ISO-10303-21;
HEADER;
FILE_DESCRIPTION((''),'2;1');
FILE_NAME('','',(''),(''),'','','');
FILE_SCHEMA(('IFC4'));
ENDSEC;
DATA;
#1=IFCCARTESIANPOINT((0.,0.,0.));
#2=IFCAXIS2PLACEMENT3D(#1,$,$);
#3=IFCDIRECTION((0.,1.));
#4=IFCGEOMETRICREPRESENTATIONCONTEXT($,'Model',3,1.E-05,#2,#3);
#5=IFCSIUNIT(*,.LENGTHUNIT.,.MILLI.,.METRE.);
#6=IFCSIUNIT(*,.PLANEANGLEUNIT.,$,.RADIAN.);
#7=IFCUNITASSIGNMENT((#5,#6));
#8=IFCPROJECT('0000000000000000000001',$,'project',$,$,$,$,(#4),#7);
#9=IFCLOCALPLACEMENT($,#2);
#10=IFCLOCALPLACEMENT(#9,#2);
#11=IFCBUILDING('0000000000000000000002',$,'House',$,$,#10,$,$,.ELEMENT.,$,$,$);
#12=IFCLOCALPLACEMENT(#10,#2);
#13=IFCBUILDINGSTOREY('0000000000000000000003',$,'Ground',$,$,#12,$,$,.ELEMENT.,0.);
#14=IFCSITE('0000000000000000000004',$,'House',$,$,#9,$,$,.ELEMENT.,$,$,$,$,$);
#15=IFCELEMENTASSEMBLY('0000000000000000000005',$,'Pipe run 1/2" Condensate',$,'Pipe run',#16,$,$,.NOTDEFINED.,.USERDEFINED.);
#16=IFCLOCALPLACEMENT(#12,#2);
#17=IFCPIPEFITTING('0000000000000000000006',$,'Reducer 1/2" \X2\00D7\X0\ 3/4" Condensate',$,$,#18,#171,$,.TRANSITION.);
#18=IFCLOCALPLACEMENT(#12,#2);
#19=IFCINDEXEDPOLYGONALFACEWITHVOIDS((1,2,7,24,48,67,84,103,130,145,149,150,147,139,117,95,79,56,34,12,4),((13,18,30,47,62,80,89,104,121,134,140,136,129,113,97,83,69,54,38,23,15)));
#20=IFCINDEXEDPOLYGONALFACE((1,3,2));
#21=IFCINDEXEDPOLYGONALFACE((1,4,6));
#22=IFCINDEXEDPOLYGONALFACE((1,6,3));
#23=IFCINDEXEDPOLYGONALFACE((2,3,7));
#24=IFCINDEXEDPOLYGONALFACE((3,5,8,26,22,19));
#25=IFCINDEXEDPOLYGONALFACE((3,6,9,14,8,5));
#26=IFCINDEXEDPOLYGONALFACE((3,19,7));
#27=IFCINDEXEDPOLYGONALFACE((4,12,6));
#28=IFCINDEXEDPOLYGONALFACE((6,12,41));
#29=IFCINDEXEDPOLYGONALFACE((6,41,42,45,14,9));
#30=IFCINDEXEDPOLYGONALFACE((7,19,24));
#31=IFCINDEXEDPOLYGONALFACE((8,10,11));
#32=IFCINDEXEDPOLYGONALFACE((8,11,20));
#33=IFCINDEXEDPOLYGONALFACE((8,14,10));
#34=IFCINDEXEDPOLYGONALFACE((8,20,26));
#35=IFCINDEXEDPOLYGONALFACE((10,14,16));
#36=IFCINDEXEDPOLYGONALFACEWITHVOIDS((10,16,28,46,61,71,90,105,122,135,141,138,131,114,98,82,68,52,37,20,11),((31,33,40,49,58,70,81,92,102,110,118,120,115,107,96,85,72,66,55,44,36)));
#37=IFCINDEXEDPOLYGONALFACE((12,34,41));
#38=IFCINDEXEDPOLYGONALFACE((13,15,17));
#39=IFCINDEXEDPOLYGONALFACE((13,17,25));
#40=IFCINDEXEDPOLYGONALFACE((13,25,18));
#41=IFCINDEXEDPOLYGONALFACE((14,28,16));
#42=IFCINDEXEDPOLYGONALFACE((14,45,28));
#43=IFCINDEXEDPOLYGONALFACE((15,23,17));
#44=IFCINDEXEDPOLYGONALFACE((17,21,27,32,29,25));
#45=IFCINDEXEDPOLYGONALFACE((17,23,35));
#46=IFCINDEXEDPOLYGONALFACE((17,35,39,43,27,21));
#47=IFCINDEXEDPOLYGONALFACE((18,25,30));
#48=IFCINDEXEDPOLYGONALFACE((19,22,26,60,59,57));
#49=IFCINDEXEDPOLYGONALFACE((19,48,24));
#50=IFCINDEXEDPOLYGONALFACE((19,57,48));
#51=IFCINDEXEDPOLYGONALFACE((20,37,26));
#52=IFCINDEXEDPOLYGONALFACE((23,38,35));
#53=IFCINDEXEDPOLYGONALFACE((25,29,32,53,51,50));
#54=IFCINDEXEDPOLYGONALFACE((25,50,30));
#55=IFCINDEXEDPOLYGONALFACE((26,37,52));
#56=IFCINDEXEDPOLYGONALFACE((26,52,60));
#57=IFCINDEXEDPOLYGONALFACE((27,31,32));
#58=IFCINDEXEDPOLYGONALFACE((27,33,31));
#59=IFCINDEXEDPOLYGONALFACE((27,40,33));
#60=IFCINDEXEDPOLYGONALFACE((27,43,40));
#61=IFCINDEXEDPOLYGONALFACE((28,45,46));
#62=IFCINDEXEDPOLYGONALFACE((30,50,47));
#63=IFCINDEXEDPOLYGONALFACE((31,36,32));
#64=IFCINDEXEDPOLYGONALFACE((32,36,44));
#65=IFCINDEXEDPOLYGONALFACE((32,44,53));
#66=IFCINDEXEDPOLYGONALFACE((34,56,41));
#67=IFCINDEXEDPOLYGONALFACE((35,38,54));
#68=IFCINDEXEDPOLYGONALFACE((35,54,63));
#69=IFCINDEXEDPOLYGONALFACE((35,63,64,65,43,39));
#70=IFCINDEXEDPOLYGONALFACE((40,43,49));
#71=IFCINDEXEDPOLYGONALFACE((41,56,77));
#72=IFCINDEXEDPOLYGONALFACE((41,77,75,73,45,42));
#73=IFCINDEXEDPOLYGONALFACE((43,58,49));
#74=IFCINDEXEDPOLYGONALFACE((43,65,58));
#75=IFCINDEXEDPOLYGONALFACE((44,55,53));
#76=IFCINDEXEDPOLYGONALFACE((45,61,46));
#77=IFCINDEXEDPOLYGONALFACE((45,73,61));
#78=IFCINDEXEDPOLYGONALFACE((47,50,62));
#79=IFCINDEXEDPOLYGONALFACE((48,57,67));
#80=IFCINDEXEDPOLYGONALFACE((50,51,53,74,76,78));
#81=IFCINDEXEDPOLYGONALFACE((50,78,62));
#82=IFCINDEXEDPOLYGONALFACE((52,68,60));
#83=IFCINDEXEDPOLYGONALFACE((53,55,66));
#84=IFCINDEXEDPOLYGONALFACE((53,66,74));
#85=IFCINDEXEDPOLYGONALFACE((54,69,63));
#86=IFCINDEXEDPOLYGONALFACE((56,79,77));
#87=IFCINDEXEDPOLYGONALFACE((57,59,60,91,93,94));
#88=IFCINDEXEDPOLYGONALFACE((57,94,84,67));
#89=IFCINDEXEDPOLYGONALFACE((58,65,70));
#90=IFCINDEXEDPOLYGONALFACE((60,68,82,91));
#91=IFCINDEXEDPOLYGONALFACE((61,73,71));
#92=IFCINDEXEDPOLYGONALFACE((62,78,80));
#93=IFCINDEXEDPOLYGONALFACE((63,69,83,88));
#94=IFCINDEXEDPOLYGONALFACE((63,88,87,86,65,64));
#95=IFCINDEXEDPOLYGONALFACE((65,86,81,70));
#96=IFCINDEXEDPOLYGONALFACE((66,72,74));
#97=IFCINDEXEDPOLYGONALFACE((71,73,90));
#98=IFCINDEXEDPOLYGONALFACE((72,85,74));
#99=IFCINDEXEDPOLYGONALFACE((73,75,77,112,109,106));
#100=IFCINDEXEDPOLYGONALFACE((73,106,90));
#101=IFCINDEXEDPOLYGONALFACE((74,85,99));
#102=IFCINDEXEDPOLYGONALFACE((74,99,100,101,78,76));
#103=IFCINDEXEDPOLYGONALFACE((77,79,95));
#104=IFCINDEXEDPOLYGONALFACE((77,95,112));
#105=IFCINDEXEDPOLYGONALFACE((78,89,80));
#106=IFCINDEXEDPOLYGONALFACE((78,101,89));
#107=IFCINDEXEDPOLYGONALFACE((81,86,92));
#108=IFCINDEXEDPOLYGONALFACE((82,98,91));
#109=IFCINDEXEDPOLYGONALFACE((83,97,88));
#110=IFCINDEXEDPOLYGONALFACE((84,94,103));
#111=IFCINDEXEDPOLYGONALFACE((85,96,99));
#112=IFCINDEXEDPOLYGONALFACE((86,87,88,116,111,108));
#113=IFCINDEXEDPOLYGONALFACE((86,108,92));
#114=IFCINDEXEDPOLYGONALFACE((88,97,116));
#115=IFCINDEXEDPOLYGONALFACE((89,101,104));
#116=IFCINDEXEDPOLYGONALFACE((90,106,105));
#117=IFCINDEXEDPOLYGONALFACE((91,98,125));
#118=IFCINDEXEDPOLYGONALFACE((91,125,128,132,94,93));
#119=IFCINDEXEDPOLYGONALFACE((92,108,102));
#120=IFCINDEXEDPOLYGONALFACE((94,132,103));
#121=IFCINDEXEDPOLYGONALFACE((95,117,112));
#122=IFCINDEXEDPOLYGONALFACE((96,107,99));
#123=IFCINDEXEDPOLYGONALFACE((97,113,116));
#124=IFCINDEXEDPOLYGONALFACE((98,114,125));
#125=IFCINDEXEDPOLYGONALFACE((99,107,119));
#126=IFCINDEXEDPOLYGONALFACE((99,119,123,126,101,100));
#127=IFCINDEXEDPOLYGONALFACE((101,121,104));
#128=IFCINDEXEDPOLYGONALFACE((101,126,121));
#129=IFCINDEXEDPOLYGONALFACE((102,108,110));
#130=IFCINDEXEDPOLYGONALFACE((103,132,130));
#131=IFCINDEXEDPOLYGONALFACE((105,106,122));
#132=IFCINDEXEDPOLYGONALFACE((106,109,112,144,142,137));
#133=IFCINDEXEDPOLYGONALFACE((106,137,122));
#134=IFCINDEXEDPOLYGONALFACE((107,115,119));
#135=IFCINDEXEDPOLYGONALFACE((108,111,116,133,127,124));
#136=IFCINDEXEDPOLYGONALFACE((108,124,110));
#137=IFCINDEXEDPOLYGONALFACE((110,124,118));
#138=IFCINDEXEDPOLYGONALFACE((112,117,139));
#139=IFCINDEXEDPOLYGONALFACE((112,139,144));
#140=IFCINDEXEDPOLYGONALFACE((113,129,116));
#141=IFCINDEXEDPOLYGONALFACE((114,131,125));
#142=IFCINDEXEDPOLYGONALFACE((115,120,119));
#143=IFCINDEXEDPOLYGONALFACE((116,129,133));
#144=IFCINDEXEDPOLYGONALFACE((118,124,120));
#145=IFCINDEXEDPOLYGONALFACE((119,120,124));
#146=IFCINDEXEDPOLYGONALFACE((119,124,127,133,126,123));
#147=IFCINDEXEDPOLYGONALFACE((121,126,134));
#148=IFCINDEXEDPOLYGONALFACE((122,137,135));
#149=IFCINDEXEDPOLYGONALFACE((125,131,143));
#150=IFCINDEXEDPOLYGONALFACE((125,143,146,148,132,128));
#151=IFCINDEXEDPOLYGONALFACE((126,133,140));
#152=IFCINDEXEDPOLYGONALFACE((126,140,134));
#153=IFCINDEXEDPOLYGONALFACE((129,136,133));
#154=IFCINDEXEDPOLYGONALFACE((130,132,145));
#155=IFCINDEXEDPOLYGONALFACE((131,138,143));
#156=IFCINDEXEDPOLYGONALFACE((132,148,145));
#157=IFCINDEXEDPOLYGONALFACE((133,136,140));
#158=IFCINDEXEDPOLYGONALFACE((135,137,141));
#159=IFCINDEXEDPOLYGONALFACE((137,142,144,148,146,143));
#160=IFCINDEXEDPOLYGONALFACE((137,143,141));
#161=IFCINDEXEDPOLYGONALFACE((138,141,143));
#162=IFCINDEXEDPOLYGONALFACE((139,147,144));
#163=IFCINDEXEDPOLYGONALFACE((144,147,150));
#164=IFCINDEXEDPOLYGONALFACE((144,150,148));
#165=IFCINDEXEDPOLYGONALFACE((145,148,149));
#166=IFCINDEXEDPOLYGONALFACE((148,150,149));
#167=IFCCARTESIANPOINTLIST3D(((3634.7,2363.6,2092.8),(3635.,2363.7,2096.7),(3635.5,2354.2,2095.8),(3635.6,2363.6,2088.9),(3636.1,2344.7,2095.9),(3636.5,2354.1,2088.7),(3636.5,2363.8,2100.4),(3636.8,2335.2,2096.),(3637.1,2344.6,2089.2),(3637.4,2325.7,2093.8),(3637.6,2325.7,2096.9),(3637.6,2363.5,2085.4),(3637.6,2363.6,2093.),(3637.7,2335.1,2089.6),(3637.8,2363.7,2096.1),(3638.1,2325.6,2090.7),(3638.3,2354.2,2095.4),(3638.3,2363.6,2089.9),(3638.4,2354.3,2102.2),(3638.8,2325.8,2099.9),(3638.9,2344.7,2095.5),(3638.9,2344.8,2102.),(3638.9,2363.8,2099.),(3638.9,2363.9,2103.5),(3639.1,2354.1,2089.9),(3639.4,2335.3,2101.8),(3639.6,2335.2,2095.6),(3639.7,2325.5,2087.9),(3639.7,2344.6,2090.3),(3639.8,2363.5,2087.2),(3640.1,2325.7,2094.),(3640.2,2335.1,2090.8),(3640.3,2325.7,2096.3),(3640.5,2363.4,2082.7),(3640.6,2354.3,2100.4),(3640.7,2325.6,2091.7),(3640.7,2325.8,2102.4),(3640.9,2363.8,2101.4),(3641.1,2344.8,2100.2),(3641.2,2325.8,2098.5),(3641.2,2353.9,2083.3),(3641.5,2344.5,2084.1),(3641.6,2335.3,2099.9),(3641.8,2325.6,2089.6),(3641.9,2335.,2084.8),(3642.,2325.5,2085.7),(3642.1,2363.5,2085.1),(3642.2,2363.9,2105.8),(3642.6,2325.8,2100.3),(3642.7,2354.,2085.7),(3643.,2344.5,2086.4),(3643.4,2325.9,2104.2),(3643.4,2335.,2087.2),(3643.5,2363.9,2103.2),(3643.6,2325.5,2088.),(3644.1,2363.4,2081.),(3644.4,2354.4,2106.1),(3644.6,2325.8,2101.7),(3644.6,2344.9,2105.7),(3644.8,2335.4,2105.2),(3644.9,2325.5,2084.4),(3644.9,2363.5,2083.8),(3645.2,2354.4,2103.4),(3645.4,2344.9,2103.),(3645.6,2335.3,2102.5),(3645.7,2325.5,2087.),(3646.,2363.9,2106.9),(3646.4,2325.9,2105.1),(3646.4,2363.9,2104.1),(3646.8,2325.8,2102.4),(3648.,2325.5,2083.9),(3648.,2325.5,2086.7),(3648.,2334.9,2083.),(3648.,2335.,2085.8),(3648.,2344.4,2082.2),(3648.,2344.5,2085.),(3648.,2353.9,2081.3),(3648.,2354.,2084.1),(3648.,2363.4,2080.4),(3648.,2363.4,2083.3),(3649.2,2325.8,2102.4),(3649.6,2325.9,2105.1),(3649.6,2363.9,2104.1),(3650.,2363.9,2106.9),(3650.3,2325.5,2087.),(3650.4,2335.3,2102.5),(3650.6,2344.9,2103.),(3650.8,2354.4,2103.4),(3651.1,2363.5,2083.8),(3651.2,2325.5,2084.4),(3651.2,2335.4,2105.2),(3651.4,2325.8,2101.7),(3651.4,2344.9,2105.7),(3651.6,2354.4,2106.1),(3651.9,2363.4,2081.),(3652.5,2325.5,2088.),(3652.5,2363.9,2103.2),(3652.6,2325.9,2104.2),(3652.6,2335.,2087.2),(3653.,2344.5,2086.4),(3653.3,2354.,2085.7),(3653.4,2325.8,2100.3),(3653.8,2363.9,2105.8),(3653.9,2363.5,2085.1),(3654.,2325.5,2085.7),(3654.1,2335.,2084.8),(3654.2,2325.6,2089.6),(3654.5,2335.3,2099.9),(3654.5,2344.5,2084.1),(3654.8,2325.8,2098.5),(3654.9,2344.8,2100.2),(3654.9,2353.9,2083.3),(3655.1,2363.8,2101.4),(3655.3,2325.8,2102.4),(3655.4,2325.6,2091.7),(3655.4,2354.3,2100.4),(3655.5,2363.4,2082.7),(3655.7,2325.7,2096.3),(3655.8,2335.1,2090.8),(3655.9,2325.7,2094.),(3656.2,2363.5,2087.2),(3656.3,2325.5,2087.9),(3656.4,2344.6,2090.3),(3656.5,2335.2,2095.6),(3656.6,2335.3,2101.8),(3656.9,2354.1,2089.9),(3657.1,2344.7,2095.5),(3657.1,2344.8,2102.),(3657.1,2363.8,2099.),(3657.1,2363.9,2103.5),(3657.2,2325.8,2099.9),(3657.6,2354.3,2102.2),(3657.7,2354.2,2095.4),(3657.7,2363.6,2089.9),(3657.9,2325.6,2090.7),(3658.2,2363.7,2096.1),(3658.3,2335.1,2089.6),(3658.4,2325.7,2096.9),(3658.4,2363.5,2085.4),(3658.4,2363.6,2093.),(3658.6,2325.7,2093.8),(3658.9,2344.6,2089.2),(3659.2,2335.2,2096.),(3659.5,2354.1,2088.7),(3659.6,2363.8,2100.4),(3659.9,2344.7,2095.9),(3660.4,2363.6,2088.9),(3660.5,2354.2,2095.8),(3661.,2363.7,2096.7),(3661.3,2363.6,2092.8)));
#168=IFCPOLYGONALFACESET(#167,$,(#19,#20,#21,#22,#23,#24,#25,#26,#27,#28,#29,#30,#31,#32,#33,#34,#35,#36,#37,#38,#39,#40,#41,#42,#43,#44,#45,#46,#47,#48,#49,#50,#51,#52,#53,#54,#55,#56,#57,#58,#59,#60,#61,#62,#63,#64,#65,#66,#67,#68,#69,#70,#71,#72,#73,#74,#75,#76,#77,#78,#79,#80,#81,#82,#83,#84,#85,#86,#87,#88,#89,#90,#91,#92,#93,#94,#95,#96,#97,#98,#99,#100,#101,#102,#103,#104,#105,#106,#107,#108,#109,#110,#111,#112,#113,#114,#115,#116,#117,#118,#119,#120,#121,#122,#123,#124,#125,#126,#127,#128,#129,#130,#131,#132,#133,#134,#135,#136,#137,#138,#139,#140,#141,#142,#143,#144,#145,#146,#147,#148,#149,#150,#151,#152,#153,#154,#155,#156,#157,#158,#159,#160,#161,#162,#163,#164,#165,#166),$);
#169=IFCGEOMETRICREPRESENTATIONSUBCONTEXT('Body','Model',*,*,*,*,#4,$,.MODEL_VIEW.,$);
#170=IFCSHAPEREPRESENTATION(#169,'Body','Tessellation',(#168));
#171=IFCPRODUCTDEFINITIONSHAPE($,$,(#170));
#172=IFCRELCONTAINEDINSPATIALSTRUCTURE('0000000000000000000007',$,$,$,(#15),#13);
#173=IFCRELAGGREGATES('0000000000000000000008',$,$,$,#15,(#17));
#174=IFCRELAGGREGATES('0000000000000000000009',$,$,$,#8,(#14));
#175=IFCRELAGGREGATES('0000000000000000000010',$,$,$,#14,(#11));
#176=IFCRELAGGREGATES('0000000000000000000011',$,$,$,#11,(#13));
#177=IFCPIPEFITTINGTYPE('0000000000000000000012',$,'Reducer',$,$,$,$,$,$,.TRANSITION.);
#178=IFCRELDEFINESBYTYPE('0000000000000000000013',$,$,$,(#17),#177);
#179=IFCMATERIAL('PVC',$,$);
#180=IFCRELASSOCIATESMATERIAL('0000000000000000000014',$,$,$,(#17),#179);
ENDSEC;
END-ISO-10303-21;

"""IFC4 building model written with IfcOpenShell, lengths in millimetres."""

from ifc_helpers import new_model, entity, si_unit, direction, origin, origin_with_axes, place, context, subcontext, project, spatial, material, type_object, element, aggregate, save


model = new_model("IFC4")

# Units and contexts
model_context = context("Model", 3, precision=1e-05, world=origin(), true_north=direction((0.0, 1.0)))
body_context = subcontext(model_context, "Body", "Model", "MODEL_VIEW")
ifc_project = project(units=[si_unit("LENGTHUNIT", "METRE", prefix="MILLI"), si_unit("PLANEANGLEUNIT", "RADIAN")], contexts=[model_context])

# Site, building, storey
site_placement = place(None, origin())
site = spatial("IfcSite", under=ifc_project, at=site_placement, Name="House", CompositionType="ELEMENT")
building_placement = place(site_placement, origin())
building = spatial("IfcBuilding", under=site, at=building_placement, Name="House", CompositionType="ELEMENT")
storey_placement = place(building_placement, origin())
storey = spatial("IfcBuildingStorey", under=building, at=storey_placement, Name="Ground", CompositionType="ELEMENT", Elevation=0.0)

# Element assembly
assembly_1_placement = place(storey_placement, origin_with_axes())
assembly_1 = element("IfcElementAssembly", 1, at=assembly_1_placement, inside=storey, Name="Pipe run 1/2\" Condensate", ObjectType="Pipe run", AssemblyPlace="NOTDEFINED", PredefinedType="USERDEFINED")
ifc_material_1 = material(Name="PVC")

# Pipe fitting
pipe_fitting_type_1 = type_object("IfcPipeFittingType", Name="Reducer", PredefinedType="TRANSITION")
pipe_fitting_1_placement = place(storey_placement, origin_with_axes())
cartesian_point_1 = entity("IfcCartesianPoint", [0.0, 7.9])
pipe_fitting_1 = element("IfcPipeFitting", 2, at=pipe_fitting_1_placement, type_object=pipe_fitting_type_1, material=ifc_material_1, Name="Reducer 1/2\" × 3/4\" Condensate", PredefinedType="TRANSITION", context=body_context, shape_type="SweptSolid", body=[
    entity("IfcRevolvedAreaSolid", entity("IfcArbitraryClosedProfileDef", "AREA", None, entity("IfcPolyline", [cartesian_point_1, entity("IfcCartesianPoint", [0.0, 10.7]), entity("IfcCartesianPoint", [38.0, 13.3]), entity("IfcCartesianPoint", [38.0, 10.5]), cartesian_point_1])), entity("IfcAxis2Placement3D", entity("IfcCartesianPoint", [3648.0, 2325.7, 2094.5]), entity("IfcDirection", [-1.0, 0.0, 0.0]), entity("IfcDirection", [0.0, 0.999783, -0.020829])), entity("IfcAxis1Placement", entity("IfcCartesianPoint", [0.0, 0.0, 0.0]), entity("IfcDirection", [1.0, 0.0, 0.0])), 6.283185),
])

aggregate(assembly_1, [pipe_fitting_1])

save(model, "model.ifc")
